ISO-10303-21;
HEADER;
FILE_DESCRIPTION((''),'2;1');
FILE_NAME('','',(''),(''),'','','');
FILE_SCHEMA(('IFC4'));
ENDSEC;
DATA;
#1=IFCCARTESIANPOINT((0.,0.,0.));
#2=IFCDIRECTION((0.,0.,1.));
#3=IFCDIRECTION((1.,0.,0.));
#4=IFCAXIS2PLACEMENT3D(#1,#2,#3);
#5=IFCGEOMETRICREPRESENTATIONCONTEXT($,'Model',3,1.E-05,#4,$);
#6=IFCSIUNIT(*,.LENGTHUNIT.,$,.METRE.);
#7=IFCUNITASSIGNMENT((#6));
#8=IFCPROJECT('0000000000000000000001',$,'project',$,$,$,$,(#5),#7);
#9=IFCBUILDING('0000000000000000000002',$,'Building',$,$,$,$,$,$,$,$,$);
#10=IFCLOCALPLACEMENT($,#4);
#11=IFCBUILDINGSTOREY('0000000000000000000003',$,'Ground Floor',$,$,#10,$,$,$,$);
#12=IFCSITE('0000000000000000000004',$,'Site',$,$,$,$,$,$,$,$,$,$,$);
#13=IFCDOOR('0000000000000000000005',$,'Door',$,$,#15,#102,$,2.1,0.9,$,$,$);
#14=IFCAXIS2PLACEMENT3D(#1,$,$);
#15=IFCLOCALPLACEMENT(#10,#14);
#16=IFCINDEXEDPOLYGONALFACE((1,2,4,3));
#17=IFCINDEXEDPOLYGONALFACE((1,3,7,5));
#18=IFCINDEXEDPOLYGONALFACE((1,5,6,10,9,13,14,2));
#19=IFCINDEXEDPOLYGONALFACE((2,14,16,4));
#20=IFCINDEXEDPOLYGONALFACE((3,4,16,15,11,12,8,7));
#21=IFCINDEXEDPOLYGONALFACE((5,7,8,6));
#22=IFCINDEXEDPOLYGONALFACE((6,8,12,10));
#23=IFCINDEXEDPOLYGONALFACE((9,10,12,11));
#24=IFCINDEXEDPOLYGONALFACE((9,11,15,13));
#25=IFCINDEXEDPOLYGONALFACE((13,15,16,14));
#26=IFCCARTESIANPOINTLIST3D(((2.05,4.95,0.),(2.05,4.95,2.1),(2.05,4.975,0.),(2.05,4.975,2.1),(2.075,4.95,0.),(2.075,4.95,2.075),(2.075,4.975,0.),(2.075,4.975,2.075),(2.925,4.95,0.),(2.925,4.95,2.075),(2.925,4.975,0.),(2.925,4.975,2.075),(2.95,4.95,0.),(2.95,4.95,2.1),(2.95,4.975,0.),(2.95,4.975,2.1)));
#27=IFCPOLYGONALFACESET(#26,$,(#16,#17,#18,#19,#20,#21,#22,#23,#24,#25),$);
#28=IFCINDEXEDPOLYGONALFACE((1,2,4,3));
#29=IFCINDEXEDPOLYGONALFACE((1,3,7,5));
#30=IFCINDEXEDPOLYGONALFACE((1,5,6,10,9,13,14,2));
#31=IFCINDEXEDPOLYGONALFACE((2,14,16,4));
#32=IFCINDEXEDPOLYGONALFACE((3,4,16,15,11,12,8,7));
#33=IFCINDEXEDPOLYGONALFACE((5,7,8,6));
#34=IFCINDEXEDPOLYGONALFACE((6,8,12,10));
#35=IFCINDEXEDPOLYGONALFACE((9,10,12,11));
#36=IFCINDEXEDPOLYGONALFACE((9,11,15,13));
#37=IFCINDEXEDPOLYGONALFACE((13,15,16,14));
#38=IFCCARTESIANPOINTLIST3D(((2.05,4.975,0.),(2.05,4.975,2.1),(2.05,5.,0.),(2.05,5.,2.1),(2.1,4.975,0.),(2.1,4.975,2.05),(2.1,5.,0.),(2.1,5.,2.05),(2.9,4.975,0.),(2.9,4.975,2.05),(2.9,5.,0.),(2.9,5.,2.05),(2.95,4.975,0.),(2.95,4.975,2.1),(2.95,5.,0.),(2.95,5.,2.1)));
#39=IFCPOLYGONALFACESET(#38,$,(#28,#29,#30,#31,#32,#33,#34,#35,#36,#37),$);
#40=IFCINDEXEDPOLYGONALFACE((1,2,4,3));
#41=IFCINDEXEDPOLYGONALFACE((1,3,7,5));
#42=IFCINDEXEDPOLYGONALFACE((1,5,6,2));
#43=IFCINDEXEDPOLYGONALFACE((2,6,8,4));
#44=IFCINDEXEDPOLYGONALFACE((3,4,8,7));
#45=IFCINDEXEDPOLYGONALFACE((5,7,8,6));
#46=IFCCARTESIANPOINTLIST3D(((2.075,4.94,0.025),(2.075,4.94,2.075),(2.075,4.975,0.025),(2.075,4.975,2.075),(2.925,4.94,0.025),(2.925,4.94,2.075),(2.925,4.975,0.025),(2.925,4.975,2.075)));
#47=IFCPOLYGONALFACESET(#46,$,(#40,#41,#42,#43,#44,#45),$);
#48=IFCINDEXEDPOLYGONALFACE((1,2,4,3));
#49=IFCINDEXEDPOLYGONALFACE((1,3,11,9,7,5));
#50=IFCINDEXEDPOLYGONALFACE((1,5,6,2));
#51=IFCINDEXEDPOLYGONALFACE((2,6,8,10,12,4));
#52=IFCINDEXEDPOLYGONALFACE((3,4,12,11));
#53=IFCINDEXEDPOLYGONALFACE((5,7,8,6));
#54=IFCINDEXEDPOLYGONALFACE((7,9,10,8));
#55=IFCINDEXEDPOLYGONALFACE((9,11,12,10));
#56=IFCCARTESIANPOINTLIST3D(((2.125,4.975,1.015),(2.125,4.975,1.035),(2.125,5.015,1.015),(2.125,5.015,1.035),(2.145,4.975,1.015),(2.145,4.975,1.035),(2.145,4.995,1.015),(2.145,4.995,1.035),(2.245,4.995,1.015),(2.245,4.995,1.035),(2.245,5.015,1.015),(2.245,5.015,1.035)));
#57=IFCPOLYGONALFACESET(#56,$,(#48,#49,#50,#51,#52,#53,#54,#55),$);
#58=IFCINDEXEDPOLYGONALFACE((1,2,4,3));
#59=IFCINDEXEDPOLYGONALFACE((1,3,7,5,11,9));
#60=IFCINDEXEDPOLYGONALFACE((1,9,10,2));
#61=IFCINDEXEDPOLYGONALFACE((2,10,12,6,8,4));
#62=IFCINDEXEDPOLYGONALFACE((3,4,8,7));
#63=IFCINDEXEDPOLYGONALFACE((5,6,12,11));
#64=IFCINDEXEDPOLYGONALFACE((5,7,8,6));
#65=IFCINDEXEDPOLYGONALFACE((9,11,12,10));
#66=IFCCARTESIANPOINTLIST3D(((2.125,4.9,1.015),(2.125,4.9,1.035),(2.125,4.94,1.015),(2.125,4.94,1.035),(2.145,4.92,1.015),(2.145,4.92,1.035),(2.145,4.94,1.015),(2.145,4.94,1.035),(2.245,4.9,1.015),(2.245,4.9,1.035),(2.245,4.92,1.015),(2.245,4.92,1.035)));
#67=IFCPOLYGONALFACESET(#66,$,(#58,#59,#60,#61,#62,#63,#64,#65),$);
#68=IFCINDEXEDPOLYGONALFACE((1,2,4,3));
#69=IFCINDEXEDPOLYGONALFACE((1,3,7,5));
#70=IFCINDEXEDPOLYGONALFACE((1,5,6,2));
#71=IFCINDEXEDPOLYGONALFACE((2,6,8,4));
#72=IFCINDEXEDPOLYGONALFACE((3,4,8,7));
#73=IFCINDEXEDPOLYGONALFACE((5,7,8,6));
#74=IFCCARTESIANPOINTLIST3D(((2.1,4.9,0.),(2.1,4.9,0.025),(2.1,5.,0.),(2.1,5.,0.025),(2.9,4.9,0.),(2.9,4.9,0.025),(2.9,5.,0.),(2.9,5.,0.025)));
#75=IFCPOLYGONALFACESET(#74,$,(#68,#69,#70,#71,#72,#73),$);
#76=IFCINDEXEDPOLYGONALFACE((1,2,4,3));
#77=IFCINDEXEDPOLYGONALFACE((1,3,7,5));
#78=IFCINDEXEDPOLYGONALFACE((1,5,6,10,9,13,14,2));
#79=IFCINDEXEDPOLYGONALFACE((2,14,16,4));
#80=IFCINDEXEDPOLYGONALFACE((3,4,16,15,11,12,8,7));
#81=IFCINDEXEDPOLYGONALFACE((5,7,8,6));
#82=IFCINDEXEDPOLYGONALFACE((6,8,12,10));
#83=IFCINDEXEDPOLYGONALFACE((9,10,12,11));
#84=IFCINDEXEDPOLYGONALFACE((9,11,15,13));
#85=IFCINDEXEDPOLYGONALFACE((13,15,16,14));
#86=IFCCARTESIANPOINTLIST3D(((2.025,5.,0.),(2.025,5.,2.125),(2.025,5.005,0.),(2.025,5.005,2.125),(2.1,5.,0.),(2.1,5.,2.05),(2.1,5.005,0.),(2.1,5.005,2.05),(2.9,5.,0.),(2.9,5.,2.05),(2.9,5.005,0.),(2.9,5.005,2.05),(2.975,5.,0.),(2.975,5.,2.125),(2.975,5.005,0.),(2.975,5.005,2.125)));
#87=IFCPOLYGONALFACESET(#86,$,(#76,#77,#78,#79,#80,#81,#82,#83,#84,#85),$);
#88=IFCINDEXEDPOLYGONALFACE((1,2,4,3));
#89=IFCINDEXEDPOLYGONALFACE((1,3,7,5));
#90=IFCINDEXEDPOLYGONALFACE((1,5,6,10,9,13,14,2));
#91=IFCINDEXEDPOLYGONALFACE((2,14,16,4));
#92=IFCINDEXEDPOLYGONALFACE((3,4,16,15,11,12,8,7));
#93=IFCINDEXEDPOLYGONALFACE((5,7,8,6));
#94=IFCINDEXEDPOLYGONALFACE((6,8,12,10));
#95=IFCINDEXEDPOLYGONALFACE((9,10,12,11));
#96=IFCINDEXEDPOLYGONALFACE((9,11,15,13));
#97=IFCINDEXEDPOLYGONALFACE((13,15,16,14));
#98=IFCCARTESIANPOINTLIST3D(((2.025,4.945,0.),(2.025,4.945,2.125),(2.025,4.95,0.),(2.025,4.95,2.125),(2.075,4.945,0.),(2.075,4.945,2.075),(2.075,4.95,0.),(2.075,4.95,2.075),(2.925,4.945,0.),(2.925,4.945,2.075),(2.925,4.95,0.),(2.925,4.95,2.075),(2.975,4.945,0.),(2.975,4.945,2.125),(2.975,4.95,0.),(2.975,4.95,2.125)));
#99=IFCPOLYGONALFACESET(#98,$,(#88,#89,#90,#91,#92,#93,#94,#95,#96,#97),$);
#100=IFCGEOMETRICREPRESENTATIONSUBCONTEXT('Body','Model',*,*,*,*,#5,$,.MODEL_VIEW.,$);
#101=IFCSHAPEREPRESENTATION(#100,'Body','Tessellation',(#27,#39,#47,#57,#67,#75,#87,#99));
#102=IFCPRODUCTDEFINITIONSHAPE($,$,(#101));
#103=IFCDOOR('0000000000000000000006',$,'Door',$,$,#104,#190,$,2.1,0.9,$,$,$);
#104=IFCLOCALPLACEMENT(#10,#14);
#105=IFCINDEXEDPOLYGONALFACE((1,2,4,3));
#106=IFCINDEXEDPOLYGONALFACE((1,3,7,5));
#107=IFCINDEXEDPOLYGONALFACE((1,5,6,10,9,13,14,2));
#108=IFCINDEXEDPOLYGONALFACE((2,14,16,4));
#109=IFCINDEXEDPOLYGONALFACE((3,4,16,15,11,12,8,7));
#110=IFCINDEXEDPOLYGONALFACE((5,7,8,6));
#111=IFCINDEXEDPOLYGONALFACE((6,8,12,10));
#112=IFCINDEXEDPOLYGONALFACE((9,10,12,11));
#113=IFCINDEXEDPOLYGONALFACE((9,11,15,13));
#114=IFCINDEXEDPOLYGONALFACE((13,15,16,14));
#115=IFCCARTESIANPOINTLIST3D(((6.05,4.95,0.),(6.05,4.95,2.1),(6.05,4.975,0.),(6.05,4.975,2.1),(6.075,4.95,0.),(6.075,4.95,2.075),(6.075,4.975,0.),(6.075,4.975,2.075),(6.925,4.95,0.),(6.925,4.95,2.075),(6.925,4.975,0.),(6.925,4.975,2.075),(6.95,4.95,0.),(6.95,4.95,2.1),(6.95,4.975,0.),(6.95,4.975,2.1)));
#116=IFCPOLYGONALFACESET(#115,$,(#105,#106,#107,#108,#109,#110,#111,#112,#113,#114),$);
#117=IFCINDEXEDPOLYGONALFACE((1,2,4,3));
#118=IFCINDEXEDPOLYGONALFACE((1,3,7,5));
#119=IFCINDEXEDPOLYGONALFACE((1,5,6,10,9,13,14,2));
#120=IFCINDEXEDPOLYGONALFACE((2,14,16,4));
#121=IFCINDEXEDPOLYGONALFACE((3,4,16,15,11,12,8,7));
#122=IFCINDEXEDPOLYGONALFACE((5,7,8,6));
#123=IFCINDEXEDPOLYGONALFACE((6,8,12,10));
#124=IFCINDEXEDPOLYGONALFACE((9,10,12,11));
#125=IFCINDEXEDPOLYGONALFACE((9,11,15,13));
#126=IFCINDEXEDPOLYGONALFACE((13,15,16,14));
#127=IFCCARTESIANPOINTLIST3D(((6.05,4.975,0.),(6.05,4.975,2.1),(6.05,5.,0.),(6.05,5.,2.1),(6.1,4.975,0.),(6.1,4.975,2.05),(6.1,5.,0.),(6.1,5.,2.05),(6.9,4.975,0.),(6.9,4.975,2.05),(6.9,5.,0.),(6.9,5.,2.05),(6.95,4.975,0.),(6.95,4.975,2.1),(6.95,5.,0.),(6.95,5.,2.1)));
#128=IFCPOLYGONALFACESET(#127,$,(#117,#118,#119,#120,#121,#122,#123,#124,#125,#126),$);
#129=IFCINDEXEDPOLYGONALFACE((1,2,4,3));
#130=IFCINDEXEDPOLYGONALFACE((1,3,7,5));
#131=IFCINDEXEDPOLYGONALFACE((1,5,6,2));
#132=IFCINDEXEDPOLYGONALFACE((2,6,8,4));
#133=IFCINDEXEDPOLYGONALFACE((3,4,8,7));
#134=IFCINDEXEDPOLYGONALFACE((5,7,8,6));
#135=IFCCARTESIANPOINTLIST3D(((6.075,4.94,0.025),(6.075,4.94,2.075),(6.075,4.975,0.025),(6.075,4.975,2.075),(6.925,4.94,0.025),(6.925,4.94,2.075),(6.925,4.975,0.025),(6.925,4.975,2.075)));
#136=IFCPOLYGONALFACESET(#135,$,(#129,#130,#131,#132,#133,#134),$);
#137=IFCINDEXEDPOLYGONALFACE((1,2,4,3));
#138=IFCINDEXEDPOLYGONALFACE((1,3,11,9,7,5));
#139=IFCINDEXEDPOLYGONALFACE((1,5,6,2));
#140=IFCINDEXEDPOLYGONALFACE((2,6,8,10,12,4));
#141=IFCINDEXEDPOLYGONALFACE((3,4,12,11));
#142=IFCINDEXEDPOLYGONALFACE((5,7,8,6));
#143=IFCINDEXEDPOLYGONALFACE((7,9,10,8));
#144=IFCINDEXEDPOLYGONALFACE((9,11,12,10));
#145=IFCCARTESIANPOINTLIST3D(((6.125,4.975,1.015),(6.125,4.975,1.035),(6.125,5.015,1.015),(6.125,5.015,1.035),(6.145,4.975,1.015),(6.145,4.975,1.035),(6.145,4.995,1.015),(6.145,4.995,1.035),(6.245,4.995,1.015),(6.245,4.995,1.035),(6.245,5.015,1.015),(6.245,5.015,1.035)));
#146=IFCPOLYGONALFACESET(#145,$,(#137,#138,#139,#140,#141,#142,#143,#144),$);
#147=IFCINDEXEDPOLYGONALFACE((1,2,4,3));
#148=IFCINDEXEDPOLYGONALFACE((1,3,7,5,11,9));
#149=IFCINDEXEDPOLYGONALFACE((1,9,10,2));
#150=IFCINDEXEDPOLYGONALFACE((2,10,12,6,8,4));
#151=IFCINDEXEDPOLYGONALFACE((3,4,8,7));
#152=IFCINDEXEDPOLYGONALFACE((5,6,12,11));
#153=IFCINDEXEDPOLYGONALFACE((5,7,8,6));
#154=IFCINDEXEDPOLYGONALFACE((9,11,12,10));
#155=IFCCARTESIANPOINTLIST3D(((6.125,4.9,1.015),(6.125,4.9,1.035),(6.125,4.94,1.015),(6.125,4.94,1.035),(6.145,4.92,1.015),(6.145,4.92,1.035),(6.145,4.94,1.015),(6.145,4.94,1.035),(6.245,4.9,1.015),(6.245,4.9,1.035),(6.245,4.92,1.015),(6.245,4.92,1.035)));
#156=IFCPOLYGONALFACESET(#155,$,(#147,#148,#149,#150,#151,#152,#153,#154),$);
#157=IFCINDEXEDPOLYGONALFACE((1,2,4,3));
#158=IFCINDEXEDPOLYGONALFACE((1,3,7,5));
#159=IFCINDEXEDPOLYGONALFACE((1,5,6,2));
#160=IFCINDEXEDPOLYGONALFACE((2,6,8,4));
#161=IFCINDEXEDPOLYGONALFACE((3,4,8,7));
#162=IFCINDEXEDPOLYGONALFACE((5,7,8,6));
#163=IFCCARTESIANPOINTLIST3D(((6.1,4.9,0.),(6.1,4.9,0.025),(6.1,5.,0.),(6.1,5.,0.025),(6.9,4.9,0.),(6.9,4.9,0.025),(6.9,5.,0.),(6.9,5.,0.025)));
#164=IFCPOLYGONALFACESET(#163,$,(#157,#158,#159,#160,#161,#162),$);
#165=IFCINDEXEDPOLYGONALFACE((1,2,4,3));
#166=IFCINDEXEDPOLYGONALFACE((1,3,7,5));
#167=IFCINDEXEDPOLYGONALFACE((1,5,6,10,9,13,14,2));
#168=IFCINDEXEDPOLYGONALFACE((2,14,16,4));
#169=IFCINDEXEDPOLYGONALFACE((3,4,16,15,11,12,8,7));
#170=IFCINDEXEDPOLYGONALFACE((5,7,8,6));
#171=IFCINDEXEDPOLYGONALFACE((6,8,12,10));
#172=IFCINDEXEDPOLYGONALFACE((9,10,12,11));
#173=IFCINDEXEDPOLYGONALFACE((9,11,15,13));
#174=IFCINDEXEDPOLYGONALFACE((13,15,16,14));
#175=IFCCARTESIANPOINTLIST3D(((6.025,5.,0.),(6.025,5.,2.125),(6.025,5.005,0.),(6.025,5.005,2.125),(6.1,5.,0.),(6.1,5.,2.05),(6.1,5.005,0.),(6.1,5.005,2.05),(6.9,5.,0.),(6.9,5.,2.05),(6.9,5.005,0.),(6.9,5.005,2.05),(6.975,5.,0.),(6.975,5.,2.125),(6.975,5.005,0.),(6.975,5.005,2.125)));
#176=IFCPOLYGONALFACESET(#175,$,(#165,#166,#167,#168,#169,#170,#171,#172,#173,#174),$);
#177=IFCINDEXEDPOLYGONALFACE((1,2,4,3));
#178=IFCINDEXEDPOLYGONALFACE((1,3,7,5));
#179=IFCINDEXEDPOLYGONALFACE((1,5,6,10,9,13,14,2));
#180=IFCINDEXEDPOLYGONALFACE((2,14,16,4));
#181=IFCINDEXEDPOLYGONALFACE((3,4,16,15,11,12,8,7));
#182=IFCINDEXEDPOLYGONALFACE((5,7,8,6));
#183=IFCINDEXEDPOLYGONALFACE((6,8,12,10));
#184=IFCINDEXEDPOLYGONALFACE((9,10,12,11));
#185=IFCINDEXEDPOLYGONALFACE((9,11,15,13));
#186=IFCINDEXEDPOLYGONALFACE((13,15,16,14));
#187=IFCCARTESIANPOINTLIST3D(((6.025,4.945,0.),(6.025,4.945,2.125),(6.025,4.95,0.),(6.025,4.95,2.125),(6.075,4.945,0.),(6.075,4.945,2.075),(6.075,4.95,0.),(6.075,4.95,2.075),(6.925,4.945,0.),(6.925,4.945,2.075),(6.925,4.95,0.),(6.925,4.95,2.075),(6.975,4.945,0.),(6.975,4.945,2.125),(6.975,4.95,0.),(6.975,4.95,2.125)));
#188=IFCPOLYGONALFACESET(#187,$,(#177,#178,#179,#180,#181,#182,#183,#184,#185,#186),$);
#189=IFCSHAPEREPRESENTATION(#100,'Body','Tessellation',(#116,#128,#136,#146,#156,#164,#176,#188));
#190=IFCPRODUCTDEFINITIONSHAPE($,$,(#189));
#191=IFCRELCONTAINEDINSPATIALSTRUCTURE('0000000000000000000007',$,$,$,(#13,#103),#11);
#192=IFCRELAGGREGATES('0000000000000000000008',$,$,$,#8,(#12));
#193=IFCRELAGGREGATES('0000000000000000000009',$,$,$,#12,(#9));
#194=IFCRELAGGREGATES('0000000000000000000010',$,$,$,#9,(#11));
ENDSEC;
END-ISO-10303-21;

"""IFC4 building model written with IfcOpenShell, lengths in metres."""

from ifc_helpers import new_model, si_unit, frame, origin_with_axes, place, context, subcontext, project, spatial, line, indexed_curve, outline, extrude, element, save


model = new_model("IFC4")

# Units and contexts
model_context = context("Model", 3, precision=1e-05, world=origin_with_axes())
body_context = subcontext(model_context, "Body", "Model", "MODEL_VIEW")
ifc_project = project(units=[si_unit("LENGTHUNIT", "METRE")], contexts=[model_context])

# Site, building, storey
site = spatial("IfcSite", under=ifc_project, Name="Site")
building = spatial("IfcBuilding", under=site, Name="Building")
storey_placement = place(None, origin_with_axes())
storey = spatial("IfcBuildingStorey", under=building, at=storey_placement, Name="Ground Floor")

# Doors
door_1_placement = place(storey_placement, frame((2.95, 5.0, 0.0), z_axis=(0.0, 0.0, 1.0), x_axis=(-1.0, 0.0, 0.0)))
element("IfcDoor", 1, at=door_1_placement, inside=storey, Name="Door", OverallHeight=2.1, OverallWidth=0.9, context=body_context, shape_type="SweptSolid", body=[
    extrude(outline(indexed_curve([(0.0, 0.0), (0.0, 2.1), (0.9, 2.1), (0.9, 0.0), (0.875, 0.0), (0.875, 2.075), (0.025, 2.075), (0.025, 0.0)], segments=[line(1, 2, 3, 4, 5, 6, 7, 8, 1)])), frame((0.0, 0.025, 0.0), z_axis=(0.0, -1.0, 0.0), x_axis=(1.0, 0.0, 0.0)), (0.0, 0.0, -1.0), 0.025),
    extrude(outline(indexed_curve([(0.0, 0.0), (0.0, 2.1), (0.9, 2.1), (0.9, 0.0), (0.85, 0.0), (0.85, 2.05), (0.05, 2.05), (0.05, 0.0)], segments=[line(1, 2, 3, 4, 5, 6, 7, 8, 1)])), frame((0.0, 0.0, 0.0), z_axis=(0.0, -1.0, 0.0), x_axis=(1.0, 0.0, 0.0)), (0.0, 0.0, -1.0), 0.025),
    extrude(outline(indexed_curve([(0.0, 0.0), (0.85, 0.0), (0.85, 0.035), (0.0, 0.035)], segments=[line(1, 2, 3, 4, 1)])), frame((0.025, 0.025, 0.025), z_axis=(0.0, 0.0, 1.0), x_axis=(1.0, 0.0, 0.0)), (0.0, 0.0, 1.0), 2.05),
    extrude(outline(indexed_curve([(0.0, 0.0), (0.0, -0.04), (-0.12, -0.04), (-0.12, -0.02), (-0.02, -0.02), (-0.02, 0.0)], segments=[line(1, 2, 3, 4, 5, 6, 1)])), frame((0.825, 0.025, 1.015), z_axis=(0.0, 0.0, 1.0), x_axis=(1.0, 0.0, 0.0)), (0.0, 0.0, 1.0), 0.02),
    extrude(outline(indexed_curve([(0.0, 0.0), (0.0, 0.04), (-0.12, 0.04), (-0.12, 0.02), (-0.02, 0.02), (-0.02, 0.0)], segments=[line(1, 2, 3, 4, 5, 6, 1)])), frame((0.825, 0.06, 1.015), z_axis=(0.0, 0.0, 1.0), x_axis=(1.0, 0.0, 0.0)), (0.0, 0.0, 1.0), 0.02),
    extrude(outline(indexed_curve([(0.0, 0.0), (0.8, 0.0), (0.8, 0.1), (0.0, 0.1)], segments=[line(1, 2, 3, 4, 1)])), frame((0.05, 0.0, 0.0), z_axis=(0.0, 0.0, 1.0), x_axis=(1.0, 0.0, 0.0)), (0.0, 0.0, 1.0), 0.025),
    extrude(outline(indexed_curve([(0.0, 0.0), (0.0, 2.125), (0.95, 2.125), (0.95, 0.0), (0.875, 0.0), (0.875, 2.05), (0.075, 2.05), (0.075, 0.0)], segments=[line(1, 2, 3, 4, 5, 6, 7, 8, 1)])), frame((-0.025, -0.005, 0.0), z_axis=(0.0, -1.0, 0.0), x_axis=(1.0, 0.0, 0.0)), (0.0, 0.0, -1.0), 0.005),
    extrude(outline(indexed_curve([(0.0, 0.0), (0.0, 2.125), (0.95, 2.125), (0.95, 0.0), (0.9, 0.0), (0.9, 2.075), (0.05, 2.075), (0.05, 0.0)], segments=[line(1, 2, 3, 4, 5, 6, 7, 8, 1)])), frame((-0.025, 0.05, 0.0), z_axis=(0.0, -1.0, 0.0), x_axis=(1.0, 0.0, 0.0)), (0.0, 0.0, -1.0), 0.005),
])
door_2_placement = place(storey_placement, frame((6.95, 5.0, 0.0), z_axis=(0.0, 0.0, 1.0), x_axis=(-1.0, 0.0, 0.0)))
element("IfcDoor", 2, at=door_2_placement, inside=storey, Name="Door", OverallHeight=2.1, OverallWidth=0.9, context=body_context, shape_type="SweptSolid", body=[
    extrude(outline(indexed_curve([(0.0, 0.0), (0.0, 2.1), (0.9, 2.1), (0.9, 0.0), (0.875, 0.0), (0.875, 2.075), (0.025, 2.075), (0.025, 0.0)], segments=[line(1, 2, 3, 4, 5, 6, 7, 8, 1)])), frame((0.0, 0.025, 0.0), z_axis=(0.0, -1.0, 0.0), x_axis=(1.0, 0.0, 0.0)), (0.0, 0.0, -1.0), 0.025),
    extrude(outline(indexed_curve([(0.0, 0.0), (0.0, 2.1), (0.9, 2.1), (0.9, 0.0), (0.85, 0.0), (0.85, 2.05), (0.05, 2.05), (0.05, 0.0)], segments=[line(1, 2, 3, 4, 5, 6, 7, 8, 1)])), frame((0.0, 0.0, 0.0), z_axis=(0.0, -1.0, 0.0), x_axis=(1.0, 0.0, 0.0)), (0.0, 0.0, -1.0), 0.025),
    extrude(outline(indexed_curve([(0.0, 0.0), (0.85, 0.0), (0.85, 0.035), (0.0, 0.035)], segments=[line(1, 2, 3, 4, 1)])), frame((0.025, 0.025, 0.025), z_axis=(0.0, 0.0, 1.0), x_axis=(1.0, 0.0, 0.0)), (0.0, 0.0, 1.0), 2.05),
    extrude(outline(indexed_curve([(0.0, 0.0), (0.0, -0.04), (-0.12, -0.04), (-0.12, -0.02), (-0.02, -0.02), (-0.02, 0.0)], segments=[line(1, 2, 3, 4, 5, 6, 1)])), frame((0.825, 0.025, 1.015), z_axis=(0.0, 0.0, 1.0), x_axis=(1.0, 0.0, 0.0)), (0.0, 0.0, 1.0), 0.02),
    extrude(outline(indexed_curve([(0.0, 0.0), (0.0, 0.04), (-0.12, 0.04), (-0.12, 0.02), (-0.02, 0.02), (-0.02, 0.0)], segments=[line(1, 2, 3, 4, 5, 6, 1)])), frame((0.825, 0.06, 1.015), z_axis=(0.0, 0.0, 1.0), x_axis=(1.0, 0.0, 0.0)), (0.0, 0.0, 1.0), 0.02),
    extrude(outline(indexed_curve([(0.0, 0.0), (0.8, 0.0), (0.8, 0.1), (0.0, 0.1)], segments=[line(1, 2, 3, 4, 1)])), frame((0.05, 0.0, 0.0), z_axis=(0.0, 0.0, 1.0), x_axis=(1.0, 0.0, 0.0)), (0.0, 0.0, 1.0), 0.025),
    extrude(outline(indexed_curve([(0.0, 0.0), (0.0, 2.125), (0.95, 2.125), (0.95, 0.0), (0.875, 0.0), (0.875, 2.05), (0.075, 2.05), (0.075, 0.0)], segments=[line(1, 2, 3, 4, 5, 6, 7, 8, 1)])), frame((-0.025, -0.005, 0.0), z_axis=(0.0, -1.0, 0.0), x_axis=(1.0, 0.0, 0.0)), (0.0, 0.0, -1.0), 0.005),
    extrude(outline(indexed_curve([(0.0, 0.0), (0.0, 2.125), (0.95, 2.125), (0.95, 0.0), (0.9, 0.0), (0.9, 2.075), (0.05, 2.075), (0.05, 0.0)], segments=[line(1, 2, 3, 4, 5, 6, 7, 8, 1)])), frame((-0.025, 0.05, 0.0), z_axis=(0.0, -1.0, 0.0), x_axis=(1.0, 0.0, 0.0)), (0.0, 0.0, -1.0), 0.005),
])

save(model, "model.ifc")
